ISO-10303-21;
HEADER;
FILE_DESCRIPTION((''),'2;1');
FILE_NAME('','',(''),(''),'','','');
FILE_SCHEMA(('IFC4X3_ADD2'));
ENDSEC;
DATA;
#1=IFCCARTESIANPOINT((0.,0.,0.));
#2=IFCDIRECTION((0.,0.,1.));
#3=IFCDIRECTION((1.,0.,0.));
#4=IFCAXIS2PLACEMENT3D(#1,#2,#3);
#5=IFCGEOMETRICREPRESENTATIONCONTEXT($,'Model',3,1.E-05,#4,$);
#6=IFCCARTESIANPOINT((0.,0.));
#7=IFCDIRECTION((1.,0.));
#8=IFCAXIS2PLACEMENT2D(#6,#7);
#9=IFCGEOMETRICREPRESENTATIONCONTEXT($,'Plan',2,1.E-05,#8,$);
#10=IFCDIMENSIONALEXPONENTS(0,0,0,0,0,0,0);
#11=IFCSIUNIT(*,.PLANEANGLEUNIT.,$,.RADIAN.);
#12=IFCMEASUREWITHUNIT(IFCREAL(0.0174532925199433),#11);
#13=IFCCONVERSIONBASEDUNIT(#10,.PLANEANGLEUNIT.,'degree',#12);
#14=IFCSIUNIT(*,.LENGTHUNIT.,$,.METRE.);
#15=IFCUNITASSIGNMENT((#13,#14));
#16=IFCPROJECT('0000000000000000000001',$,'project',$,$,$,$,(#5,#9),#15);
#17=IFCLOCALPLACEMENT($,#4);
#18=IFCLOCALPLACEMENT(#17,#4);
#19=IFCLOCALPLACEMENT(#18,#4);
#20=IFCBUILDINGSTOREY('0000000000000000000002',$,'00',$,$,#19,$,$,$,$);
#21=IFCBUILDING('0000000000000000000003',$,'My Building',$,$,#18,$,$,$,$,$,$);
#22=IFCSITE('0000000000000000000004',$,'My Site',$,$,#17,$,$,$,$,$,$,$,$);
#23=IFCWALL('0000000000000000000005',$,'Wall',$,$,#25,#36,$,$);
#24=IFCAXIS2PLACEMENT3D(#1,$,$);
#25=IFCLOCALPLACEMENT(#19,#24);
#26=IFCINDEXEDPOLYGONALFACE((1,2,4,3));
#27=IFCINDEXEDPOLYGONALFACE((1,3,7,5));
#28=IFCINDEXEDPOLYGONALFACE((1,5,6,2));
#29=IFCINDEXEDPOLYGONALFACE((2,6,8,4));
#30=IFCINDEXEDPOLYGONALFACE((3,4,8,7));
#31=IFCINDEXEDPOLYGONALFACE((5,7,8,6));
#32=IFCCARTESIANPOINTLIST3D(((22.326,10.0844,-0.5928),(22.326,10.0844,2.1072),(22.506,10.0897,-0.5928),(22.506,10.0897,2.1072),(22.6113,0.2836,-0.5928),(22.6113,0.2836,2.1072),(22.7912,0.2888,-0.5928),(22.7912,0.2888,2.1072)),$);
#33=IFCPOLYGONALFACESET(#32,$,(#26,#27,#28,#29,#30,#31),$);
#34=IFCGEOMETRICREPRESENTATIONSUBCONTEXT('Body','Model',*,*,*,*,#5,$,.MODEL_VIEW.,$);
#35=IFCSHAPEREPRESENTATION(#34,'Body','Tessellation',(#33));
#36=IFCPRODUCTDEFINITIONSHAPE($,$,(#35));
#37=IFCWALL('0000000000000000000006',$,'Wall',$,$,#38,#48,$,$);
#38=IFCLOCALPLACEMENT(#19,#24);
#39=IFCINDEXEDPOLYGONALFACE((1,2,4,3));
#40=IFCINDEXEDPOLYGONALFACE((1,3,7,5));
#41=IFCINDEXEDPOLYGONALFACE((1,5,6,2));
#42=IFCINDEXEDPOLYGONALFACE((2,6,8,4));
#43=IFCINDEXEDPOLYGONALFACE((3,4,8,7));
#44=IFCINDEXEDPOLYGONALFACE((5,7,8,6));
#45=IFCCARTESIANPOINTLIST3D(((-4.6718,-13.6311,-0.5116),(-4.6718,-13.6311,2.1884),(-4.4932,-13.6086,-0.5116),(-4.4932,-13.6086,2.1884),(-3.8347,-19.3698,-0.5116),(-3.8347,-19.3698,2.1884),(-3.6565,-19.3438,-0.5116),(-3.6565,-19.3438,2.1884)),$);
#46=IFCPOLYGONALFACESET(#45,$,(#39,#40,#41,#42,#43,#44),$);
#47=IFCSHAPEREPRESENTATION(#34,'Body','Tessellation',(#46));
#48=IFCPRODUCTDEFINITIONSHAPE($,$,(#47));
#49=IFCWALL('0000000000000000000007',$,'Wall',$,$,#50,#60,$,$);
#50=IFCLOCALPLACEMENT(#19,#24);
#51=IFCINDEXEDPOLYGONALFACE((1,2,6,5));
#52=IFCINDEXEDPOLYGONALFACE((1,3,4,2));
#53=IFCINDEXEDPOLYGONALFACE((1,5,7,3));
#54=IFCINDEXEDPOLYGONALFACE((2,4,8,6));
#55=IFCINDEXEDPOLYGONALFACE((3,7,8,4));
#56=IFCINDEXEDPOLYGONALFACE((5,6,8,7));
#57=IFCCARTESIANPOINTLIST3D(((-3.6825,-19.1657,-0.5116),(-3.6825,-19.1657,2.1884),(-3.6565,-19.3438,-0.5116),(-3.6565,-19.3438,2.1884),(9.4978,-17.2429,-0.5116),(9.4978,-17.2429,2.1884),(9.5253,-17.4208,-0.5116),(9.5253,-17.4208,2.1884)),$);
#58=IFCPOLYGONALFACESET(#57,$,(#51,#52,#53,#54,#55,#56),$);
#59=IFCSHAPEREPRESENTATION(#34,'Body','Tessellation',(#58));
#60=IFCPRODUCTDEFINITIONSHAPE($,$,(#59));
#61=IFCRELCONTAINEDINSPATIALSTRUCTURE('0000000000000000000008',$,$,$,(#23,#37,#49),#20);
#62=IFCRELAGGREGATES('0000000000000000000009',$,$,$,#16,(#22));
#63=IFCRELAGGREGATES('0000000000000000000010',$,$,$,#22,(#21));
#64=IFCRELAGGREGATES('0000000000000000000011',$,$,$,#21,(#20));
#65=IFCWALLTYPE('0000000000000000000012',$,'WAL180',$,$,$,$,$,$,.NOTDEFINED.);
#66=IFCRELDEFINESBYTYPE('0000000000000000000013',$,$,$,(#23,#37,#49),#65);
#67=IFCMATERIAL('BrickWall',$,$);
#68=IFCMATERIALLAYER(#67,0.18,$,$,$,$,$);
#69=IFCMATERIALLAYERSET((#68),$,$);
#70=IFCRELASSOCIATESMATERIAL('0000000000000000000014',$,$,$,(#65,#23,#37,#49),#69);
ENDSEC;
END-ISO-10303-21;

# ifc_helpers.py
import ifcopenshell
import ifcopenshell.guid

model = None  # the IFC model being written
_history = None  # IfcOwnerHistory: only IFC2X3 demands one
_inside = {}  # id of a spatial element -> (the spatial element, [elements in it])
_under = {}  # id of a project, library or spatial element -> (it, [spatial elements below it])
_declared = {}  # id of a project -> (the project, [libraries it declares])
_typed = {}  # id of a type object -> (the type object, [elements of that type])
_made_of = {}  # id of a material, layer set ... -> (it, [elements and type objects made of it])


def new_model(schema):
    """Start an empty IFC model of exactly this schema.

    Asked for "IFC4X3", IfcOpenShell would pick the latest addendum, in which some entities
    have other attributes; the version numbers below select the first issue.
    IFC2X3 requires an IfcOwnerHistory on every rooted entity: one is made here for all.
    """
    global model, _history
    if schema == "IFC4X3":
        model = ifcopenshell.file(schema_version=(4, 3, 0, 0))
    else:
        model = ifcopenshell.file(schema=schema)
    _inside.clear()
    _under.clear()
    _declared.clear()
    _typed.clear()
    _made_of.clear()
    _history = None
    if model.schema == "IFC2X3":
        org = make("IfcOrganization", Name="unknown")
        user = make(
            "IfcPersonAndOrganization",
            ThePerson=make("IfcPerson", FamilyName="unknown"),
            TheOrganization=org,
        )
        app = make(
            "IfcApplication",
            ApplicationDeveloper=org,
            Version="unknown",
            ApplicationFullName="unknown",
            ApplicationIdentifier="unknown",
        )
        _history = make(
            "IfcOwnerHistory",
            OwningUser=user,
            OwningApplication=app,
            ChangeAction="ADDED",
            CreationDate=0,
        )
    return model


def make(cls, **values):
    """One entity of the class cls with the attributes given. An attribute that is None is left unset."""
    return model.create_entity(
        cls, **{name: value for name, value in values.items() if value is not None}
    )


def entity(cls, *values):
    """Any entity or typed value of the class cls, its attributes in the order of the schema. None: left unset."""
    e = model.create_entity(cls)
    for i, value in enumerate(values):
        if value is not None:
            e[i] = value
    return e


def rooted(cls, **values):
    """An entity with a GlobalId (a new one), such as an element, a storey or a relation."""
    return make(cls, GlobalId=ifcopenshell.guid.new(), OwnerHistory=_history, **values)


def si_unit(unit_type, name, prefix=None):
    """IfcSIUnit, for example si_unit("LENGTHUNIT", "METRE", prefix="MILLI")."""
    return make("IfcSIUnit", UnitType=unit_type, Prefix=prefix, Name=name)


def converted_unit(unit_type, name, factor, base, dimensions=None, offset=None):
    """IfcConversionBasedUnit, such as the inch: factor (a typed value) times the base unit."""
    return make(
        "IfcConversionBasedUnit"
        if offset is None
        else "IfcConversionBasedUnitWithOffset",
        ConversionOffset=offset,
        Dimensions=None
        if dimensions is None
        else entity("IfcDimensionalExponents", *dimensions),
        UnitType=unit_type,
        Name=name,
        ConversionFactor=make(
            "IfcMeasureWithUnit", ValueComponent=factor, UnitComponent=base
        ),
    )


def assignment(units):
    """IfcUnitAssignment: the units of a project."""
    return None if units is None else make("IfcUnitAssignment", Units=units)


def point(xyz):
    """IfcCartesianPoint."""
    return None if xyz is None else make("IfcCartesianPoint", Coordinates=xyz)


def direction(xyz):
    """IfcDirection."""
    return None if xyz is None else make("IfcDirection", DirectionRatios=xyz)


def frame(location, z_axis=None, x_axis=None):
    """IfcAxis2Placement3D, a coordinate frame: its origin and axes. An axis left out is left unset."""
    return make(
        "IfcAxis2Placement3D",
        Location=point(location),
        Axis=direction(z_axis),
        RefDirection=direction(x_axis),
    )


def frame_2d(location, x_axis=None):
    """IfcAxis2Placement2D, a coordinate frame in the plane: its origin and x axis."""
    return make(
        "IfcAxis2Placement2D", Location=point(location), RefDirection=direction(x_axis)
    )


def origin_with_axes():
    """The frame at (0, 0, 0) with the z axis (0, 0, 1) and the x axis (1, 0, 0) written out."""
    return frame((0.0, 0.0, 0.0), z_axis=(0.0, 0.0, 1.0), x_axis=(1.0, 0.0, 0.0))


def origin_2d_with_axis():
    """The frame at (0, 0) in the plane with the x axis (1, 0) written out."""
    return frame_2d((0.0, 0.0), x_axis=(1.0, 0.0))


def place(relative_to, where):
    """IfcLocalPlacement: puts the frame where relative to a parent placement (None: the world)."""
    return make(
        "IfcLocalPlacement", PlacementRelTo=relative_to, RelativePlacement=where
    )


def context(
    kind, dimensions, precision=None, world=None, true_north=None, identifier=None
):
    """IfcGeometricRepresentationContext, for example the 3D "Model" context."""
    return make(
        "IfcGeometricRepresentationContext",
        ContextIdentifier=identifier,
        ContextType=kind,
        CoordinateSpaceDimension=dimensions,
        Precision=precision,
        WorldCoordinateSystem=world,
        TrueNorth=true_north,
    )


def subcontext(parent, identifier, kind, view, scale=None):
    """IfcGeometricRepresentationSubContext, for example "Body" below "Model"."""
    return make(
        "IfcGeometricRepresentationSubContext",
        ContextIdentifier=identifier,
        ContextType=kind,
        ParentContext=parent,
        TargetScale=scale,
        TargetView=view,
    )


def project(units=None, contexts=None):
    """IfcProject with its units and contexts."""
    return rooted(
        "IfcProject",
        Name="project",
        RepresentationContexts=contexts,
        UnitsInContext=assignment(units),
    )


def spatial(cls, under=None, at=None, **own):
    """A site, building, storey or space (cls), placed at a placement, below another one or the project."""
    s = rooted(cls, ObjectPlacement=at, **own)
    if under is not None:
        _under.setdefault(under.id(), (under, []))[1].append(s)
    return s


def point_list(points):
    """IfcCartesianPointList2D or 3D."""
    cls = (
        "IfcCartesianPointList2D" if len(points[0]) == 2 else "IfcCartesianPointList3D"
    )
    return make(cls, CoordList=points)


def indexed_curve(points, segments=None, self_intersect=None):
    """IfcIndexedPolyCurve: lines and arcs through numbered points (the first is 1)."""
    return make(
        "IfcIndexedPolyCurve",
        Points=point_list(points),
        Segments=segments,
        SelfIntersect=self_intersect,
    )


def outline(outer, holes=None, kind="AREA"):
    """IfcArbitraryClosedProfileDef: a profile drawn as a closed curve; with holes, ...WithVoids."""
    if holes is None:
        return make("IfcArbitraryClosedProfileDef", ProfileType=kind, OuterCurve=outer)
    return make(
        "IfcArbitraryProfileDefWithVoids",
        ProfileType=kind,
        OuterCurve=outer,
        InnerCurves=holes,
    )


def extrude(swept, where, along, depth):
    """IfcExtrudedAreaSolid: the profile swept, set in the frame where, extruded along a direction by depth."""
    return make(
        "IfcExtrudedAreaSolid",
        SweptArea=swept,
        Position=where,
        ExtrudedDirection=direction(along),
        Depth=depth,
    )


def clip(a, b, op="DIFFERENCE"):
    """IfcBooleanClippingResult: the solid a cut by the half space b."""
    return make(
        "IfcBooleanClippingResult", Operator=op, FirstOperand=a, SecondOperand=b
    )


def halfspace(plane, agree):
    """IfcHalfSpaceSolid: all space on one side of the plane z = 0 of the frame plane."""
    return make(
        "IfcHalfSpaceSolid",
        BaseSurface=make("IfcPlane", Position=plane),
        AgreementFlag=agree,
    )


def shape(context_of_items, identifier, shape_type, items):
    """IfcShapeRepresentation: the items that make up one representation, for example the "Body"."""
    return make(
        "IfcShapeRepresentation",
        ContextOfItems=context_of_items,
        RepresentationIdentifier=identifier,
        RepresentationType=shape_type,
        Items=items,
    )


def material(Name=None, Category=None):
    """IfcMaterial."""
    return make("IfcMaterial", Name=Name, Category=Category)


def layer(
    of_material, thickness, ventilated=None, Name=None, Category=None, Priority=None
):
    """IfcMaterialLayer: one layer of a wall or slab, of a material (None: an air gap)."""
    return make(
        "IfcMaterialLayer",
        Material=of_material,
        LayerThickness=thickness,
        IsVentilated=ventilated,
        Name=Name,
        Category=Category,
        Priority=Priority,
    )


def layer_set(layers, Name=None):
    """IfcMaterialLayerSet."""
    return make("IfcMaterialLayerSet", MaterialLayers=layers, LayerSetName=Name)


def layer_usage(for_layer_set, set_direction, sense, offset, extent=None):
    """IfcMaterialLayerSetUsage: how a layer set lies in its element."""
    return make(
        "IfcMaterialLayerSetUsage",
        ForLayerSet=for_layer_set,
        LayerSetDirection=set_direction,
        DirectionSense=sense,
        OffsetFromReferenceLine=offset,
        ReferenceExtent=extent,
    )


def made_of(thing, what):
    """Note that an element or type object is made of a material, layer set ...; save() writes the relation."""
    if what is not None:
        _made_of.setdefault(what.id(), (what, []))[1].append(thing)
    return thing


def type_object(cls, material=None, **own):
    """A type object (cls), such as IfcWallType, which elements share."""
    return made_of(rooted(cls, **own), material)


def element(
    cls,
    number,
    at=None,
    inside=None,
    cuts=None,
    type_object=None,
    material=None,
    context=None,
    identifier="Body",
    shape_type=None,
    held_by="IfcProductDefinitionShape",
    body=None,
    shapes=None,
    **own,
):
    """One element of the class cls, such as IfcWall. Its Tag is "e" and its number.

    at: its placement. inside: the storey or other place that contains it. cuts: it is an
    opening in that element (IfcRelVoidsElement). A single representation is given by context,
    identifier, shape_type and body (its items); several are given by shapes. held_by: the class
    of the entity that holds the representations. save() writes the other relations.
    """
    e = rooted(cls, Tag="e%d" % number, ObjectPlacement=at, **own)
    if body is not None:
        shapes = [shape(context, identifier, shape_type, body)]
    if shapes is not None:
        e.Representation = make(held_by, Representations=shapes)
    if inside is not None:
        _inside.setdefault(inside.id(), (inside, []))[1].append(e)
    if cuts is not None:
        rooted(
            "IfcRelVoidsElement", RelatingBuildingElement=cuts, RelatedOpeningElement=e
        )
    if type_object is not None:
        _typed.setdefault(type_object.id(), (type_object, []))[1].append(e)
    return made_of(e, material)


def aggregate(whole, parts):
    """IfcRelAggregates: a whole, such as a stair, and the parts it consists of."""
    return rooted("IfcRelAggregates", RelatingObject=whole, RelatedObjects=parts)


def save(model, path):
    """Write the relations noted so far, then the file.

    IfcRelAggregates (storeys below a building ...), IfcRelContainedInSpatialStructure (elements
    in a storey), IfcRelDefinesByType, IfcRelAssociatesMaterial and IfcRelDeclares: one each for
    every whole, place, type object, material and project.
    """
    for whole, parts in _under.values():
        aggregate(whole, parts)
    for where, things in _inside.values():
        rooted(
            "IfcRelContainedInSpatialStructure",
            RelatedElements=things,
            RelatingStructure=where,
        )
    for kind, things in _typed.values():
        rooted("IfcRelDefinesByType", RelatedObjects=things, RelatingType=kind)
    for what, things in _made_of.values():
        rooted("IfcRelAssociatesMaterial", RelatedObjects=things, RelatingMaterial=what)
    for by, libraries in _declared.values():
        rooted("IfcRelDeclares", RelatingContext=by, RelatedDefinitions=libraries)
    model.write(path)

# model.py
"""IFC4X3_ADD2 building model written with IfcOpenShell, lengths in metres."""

from ifc_helpers import new_model, entity, si_unit, converted_unit, frame, origin_with_axes, origin_2d_with_axis, place, context, subcontext, project, spatial, indexed_curve, outline, extrude, clip, halfspace, material, layer, layer_set, layer_usage, type_object, element, save


model = new_model("IFC4X3_ADD2")

# Units and contexts
model_context = context("Model", 3, precision=1e-05, world=origin_with_axes())
plan_context = context("Plan", 2, precision=1e-05, world=origin_2d_with_axis())
body_context = subcontext(model_context, "Body", "Model", "MODEL_VIEW")
ifc_project = project(units=[converted_unit("PLANEANGLEUNIT", "degree", entity("IfcReal", 0.0174532925199433), si_unit("PLANEANGLEUNIT", "RADIAN"), dimensions=[0, 0, 0, 0, 0, 0, 0]), si_unit("LENGTHUNIT", "METRE")], contexts=[model_context, plan_context])

# Site, building, storey
site_placement = place(None, origin_with_axes())
site = spatial("IfcSite", under=ifc_project, at=site_placement, Name="My Site")
building_placement = place(site_placement, origin_with_axes())
building = spatial("IfcBuilding", under=site, at=building_placement, Name="My Building")
storey_placement = place(building_placement, origin_with_axes())
storey = spatial("IfcBuildingStorey", under=building, at=storey_placement, Name="00")

# Walls
ifc_material = material(Name="BrickWall")
ifc_layer = layer(ifc_material, 0.18)
ifc_layer_set = layer_set([ifc_layer])
wall_type = type_object("IfcWallType", Name="WAL180", PredefinedType="NOTDEFINED", material=ifc_layer_set)
ifc_layer_usage_1 = layer_usage(ifc_layer_set, "AXIS2", "POSITIVE", 0.0)
wall_1_placement = place(storey_placement, frame((22.7912, 0.2888, -0.5928), z_axis=(0.0, 0.0, 1.0), x_axis=(-0.029096, 0.999577, 0.0)))
element("IfcWall", 1, at=wall_1_placement, inside=storey, type_object=wall_type, material=ifc_layer_usage_1, Name="Wall", context=body_context, shape_type="SweptSolid", body=[
    extrude(outline(indexed_curve([(0.0, 0.0), (0.0, 0.18), (9.805, 0.18), (9.805, 0.0), (0.0, 0.0)], self_intersect=False)), origin_with_axes(), (0.0, 0.0, 1.0), 2.7),
])
ifc_layer_usage_2 = layer_usage(ifc_layer_set, "AXIS2", "POSITIVE", 0.0)
wall_2_placement = place(storey_placement, frame((-3.6565, -19.3438, -0.5116), z_axis=(0.0, 0.0, 1.0), x_axis=(-0.144352, 0.989526, 0.0)))
element("IfcWall", 2, at=wall_2_placement, inside=storey, type_object=wall_type, material=ifc_layer_usage_2, Name="Wall", context=body_context, shape_type="Clipping", body=[
    clip(extrude(outline(indexed_curve([(0.0, 0.0), (0.0, 0.18), (10.4218, 0.18), (10.4218, 0.0), (0.0, 0.0)], self_intersect=False)), origin_with_axes(), (0.0, 0.0, 1.0), 2.7), halfspace(frame((5.7959, 0.0, 0.5116), z_axis=(0.999812, -0.0194, 0.0), x_axis=(-0.0194, -0.999812, 0.0)), False)),
])
ifc_layer_usage_3 = layer_usage(ifc_layer_set, "AXIS2", "POSITIVE", 0.0)
wall_3_placement = place(storey_placement, frame((-3.6565, -19.3438, -0.5116), z_axis=(0.0, 0.0, 1.0), x_axis=(0.989526, 0.144352, 0.0)))
element("IfcWall", 3, at=wall_3_placement, inside=storey, type_object=wall_type, material=ifc_layer_usage_3, Name="Wall", context=body_context, shape_type="Clipping", body=[
    clip(extrude(outline(indexed_curve([(0.0, 0.0), (0.0, 0.18), (23.9284, 0.18), (23.9284, 0.0), (0.0, 0.0)], self_intersect=False)), origin_with_axes(), (0.0, 0.0, 1.0), 2.7), halfspace(frame((13.3213, 0.0, 0.5116), z_axis=(0.999962, 0.008712, 0.0), x_axis=(0.008712, -0.999962, 0.0)), False)),
])

save(model, "model.ifc")
